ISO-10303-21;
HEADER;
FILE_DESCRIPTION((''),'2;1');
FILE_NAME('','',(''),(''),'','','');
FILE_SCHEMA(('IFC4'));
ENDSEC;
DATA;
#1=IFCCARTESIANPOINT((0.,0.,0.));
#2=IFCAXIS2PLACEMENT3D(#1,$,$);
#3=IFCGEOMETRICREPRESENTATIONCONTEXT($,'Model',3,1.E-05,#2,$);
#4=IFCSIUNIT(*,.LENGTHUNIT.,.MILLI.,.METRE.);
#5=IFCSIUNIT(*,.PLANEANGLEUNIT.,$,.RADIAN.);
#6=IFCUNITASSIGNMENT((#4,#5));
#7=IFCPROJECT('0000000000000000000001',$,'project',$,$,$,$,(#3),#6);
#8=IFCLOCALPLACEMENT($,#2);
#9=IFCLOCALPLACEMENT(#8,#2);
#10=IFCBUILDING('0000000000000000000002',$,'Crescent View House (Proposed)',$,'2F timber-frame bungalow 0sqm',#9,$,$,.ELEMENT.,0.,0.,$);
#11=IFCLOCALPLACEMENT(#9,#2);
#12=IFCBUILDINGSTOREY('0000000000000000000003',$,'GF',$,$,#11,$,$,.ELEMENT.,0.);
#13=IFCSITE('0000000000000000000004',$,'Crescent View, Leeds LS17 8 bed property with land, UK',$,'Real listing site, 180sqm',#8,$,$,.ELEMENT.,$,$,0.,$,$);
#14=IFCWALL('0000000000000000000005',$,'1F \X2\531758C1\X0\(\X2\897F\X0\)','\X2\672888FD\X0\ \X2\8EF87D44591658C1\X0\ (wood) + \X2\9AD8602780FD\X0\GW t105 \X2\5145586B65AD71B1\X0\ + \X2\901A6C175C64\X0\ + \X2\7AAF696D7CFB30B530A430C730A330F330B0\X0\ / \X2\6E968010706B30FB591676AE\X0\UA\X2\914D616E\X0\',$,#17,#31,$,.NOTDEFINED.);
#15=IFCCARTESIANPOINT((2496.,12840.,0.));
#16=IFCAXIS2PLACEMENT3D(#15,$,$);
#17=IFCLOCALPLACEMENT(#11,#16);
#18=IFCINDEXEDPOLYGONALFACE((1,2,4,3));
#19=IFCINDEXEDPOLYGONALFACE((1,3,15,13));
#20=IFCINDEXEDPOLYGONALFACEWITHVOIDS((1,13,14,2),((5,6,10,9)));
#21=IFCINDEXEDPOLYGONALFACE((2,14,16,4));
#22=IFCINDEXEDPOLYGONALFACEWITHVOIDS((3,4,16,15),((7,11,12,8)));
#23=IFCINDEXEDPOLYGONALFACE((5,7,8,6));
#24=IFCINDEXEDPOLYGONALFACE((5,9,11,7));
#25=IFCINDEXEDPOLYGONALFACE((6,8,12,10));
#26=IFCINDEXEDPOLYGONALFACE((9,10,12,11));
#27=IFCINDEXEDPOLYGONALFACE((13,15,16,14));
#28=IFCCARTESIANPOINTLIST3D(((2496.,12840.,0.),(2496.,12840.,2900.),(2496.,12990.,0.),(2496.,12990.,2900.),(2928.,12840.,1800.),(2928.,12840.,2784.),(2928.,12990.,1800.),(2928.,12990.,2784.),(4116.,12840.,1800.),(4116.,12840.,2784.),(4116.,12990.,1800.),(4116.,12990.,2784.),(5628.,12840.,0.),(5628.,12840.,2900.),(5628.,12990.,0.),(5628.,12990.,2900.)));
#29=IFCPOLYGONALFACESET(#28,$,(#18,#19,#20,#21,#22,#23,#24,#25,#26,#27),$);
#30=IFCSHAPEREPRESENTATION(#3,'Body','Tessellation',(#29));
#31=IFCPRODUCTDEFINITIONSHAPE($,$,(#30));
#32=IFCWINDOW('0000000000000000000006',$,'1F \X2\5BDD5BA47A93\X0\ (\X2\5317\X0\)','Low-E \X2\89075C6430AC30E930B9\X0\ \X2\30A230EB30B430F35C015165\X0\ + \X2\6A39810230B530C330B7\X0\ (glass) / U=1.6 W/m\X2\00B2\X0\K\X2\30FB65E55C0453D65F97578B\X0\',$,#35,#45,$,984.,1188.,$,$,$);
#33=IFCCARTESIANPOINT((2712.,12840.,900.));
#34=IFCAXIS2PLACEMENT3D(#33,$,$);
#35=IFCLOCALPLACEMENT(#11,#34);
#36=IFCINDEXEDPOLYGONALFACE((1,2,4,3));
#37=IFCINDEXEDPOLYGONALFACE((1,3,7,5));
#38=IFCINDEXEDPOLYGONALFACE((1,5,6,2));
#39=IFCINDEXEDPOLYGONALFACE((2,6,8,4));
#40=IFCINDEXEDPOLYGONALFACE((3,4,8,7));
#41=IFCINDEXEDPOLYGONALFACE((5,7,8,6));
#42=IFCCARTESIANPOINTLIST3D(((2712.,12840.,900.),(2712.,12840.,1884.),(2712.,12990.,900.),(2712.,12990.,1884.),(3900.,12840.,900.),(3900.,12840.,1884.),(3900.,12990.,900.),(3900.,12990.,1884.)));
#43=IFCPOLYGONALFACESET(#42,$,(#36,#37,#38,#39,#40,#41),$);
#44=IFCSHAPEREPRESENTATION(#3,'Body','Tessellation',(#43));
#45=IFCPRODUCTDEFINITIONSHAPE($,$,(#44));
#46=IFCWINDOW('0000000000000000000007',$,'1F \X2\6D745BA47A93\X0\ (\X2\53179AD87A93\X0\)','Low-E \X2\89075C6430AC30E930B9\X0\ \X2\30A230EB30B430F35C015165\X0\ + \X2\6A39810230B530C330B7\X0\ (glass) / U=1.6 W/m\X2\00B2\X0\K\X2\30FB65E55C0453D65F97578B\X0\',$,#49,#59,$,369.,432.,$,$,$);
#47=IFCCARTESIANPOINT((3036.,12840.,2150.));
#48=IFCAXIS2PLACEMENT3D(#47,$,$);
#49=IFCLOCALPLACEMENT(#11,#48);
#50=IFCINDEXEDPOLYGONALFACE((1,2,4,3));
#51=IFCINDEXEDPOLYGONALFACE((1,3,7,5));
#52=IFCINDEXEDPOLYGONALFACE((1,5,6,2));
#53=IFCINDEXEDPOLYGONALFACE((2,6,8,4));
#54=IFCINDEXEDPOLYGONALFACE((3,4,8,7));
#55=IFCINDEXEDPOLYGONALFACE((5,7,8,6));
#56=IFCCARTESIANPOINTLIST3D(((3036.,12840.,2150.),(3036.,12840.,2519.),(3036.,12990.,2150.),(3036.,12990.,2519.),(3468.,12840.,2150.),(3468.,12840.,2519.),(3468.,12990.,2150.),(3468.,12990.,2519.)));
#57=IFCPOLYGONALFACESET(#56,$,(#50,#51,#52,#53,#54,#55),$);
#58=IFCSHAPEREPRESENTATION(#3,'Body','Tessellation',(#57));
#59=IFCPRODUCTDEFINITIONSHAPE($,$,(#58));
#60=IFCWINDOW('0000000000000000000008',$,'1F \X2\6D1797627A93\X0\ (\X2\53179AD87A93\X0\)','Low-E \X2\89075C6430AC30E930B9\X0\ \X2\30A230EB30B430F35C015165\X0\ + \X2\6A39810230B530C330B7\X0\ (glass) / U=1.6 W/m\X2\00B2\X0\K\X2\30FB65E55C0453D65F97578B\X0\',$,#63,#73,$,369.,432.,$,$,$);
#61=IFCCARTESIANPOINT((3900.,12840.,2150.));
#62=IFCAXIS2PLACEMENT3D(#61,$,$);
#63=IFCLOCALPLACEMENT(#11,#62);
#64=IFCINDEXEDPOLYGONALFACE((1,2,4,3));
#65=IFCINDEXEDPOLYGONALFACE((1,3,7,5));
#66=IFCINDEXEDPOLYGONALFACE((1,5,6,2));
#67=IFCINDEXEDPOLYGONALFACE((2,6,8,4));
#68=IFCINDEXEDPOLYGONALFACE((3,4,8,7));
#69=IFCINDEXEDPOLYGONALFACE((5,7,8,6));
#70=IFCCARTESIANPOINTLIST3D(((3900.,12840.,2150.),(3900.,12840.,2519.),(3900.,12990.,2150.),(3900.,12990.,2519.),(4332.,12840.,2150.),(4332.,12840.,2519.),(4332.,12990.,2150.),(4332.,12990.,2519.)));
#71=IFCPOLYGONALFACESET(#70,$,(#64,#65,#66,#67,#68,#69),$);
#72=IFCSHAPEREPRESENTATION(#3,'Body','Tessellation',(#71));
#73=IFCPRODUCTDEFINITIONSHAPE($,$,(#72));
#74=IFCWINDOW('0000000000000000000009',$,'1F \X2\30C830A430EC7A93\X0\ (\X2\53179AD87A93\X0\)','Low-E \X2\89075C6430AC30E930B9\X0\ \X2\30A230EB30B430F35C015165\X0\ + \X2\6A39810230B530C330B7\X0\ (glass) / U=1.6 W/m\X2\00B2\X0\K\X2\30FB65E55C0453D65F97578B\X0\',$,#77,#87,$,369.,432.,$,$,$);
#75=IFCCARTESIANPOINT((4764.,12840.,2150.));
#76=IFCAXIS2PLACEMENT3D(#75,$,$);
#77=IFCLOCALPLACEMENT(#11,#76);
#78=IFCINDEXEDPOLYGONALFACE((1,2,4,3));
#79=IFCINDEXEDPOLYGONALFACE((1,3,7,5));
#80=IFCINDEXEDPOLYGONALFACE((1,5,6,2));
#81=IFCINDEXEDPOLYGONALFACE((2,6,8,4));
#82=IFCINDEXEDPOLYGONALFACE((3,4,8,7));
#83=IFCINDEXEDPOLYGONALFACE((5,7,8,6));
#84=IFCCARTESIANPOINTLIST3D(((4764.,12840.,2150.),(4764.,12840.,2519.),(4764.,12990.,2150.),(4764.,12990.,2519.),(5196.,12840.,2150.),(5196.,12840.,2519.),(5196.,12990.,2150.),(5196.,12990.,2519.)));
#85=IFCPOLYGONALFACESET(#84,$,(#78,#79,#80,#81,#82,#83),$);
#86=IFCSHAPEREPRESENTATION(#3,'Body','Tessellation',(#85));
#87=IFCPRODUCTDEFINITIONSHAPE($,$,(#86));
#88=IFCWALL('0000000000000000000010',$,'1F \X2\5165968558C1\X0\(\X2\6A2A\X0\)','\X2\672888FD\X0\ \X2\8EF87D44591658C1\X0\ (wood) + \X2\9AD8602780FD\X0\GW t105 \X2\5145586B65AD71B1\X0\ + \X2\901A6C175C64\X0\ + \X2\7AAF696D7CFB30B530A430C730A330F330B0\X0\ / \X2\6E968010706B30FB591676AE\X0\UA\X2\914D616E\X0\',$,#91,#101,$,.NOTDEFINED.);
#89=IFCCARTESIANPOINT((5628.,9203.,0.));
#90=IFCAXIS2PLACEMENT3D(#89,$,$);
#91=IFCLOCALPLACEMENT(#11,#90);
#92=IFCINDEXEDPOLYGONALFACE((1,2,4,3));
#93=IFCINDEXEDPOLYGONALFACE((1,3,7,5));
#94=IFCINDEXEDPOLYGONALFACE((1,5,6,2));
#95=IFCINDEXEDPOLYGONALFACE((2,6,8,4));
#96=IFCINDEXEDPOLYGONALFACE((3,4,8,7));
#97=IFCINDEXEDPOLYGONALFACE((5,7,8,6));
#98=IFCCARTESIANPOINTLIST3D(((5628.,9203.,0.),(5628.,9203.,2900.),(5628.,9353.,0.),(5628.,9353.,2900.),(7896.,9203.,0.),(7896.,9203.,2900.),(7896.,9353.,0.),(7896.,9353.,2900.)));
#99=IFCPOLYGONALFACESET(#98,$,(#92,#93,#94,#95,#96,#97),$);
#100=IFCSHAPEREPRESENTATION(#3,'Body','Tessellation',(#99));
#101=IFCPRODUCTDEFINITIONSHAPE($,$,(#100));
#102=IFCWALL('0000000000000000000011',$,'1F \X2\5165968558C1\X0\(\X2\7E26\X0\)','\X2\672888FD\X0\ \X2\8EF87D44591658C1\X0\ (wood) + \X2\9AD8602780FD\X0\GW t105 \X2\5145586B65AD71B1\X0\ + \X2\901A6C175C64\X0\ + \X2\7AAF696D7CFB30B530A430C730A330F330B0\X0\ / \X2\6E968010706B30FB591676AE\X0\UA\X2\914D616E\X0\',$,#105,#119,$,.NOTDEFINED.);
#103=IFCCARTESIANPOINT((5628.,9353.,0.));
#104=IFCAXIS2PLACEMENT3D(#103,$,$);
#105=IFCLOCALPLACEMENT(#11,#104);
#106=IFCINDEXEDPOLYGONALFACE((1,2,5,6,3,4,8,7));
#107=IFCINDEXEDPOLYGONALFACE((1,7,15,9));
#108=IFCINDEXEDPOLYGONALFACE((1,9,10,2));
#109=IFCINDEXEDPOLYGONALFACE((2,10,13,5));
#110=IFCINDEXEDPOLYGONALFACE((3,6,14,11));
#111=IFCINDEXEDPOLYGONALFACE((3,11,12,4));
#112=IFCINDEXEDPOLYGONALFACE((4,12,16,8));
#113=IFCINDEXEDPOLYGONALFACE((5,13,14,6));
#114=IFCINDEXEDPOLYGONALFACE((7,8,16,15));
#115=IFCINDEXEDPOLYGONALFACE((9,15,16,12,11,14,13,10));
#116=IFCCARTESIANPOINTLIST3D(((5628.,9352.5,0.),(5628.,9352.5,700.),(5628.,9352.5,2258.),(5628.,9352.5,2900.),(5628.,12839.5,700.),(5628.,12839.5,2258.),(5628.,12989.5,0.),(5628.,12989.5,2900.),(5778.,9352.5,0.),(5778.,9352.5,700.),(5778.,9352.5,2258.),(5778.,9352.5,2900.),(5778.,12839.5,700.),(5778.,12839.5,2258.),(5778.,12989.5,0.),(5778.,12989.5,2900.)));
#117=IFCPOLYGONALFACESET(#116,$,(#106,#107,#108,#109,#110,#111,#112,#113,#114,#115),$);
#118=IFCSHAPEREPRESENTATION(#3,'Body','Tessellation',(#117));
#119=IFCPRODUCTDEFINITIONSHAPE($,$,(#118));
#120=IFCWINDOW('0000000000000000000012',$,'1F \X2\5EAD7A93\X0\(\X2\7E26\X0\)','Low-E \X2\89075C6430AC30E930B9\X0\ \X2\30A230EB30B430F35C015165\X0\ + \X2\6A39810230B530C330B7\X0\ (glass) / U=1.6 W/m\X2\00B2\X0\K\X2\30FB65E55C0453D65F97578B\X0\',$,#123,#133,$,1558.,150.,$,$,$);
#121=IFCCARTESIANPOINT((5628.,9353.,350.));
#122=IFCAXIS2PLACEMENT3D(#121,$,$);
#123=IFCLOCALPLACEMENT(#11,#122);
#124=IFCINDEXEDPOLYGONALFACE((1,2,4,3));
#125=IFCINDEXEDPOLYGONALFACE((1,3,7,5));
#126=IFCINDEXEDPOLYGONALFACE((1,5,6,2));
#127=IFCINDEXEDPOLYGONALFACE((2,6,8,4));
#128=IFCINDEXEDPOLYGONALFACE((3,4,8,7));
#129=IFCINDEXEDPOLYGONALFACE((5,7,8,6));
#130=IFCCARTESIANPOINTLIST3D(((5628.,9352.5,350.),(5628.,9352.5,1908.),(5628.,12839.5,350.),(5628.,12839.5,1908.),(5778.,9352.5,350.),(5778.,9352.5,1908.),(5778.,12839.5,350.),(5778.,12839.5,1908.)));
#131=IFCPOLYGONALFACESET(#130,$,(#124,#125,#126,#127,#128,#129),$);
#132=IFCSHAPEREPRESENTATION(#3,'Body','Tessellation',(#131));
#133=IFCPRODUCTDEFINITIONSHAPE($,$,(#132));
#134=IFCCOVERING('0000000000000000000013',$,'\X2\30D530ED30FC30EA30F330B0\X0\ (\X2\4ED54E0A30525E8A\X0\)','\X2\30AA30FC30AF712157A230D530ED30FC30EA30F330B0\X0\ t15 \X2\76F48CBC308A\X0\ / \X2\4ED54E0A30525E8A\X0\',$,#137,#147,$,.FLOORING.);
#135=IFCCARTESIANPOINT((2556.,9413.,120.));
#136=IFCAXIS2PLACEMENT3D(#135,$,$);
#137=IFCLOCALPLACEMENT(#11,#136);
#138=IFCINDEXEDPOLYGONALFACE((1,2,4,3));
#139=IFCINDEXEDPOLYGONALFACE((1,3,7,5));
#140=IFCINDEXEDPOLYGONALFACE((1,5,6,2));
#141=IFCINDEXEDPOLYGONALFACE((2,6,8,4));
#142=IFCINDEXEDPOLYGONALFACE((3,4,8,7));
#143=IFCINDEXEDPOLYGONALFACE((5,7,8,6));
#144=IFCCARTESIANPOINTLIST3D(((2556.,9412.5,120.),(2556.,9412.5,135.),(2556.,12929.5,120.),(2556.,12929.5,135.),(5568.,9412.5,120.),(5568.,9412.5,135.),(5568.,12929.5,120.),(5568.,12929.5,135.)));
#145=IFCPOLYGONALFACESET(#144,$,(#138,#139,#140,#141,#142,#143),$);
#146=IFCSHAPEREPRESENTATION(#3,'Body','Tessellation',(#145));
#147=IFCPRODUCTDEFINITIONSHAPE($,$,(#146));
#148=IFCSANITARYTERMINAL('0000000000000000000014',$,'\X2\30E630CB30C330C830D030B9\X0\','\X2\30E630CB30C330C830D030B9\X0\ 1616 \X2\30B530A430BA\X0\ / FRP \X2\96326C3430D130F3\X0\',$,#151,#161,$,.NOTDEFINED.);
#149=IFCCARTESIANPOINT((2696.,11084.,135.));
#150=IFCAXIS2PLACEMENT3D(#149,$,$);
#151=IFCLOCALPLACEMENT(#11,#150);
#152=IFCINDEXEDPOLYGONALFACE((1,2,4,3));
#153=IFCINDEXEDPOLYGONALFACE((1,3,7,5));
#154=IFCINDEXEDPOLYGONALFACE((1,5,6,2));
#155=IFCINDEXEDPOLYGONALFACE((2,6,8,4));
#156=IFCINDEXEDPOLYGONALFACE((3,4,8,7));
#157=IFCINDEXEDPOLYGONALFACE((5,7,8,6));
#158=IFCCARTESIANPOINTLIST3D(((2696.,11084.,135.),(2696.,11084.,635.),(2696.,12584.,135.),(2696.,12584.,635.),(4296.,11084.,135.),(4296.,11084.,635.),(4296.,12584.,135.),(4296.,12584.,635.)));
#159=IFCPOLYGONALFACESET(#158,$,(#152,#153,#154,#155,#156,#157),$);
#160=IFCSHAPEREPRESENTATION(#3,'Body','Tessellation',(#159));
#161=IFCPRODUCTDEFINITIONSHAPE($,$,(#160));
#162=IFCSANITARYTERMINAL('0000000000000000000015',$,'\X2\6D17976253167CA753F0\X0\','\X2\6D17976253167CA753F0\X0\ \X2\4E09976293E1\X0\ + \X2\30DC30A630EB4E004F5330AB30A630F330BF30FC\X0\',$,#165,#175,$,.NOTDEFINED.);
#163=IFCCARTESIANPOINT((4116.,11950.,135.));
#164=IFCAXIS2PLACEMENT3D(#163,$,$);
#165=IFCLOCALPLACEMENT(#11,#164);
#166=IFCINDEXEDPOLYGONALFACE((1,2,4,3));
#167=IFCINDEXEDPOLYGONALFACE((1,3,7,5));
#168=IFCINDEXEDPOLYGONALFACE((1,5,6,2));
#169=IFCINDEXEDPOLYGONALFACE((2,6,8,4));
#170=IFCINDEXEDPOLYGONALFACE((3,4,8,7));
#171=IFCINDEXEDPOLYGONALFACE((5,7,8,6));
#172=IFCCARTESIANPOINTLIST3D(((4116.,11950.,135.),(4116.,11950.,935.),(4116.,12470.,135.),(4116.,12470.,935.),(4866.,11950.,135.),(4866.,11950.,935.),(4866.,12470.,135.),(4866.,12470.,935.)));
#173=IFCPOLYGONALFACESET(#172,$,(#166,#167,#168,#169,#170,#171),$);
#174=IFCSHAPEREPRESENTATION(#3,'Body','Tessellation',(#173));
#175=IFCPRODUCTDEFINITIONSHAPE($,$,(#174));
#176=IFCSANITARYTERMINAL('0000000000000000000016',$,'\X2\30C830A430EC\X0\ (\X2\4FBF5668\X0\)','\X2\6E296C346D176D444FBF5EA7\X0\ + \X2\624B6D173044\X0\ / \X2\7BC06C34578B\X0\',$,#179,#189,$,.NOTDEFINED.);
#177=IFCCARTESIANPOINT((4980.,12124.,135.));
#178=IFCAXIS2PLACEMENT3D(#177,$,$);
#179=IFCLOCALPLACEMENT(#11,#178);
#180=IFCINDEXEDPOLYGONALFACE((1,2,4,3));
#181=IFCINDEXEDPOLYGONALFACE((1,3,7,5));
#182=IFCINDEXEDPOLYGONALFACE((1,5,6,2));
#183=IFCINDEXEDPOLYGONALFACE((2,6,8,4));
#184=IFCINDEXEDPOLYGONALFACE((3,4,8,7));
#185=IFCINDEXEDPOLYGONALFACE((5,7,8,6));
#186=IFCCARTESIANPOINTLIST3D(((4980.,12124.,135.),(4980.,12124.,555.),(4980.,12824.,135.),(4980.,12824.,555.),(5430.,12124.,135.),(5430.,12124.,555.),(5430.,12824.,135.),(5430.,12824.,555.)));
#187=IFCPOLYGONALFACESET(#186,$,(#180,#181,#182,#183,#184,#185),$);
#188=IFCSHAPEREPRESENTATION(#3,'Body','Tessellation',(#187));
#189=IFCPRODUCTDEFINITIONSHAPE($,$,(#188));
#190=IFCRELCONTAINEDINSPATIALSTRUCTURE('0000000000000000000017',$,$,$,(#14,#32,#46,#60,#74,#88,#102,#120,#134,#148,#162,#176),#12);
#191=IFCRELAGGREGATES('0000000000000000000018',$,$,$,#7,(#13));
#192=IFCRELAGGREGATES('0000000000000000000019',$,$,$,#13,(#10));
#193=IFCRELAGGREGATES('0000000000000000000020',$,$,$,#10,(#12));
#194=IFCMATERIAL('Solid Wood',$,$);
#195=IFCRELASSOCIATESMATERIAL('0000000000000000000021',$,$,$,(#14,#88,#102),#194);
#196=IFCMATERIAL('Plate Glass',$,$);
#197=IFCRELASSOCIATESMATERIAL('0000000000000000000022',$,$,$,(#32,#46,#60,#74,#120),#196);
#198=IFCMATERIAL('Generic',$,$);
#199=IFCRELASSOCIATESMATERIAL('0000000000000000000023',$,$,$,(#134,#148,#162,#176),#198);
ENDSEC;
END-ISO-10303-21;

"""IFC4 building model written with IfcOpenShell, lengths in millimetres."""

from ifc_helpers import new_model, si_unit, frame, frame_2d, origin, place, context, project, spatial, rectangle, extrude, material, element, fill, save


model = new_model("IFC4")

# Units and contexts
model_context = context("Model", 3, precision=1e-05, world=origin())
ifc_project = project(units=[si_unit("LENGTHUNIT", "METRE", prefix="MILLI"), si_unit("PLANEANGLEUNIT", "RADIAN")], contexts=[model_context])

# Site, building, storey
site_placement = place(None, origin())
site = spatial("IfcSite", under=ifc_project, at=site_placement, Name="Crescent View, Leeds LS17 8 bed property with land, UK", ObjectType="Real listing site, 180sqm", CompositionType="ELEMENT", RefElevation=0.0)
building_placement = place(site_placement, origin())
building = spatial("IfcBuilding", under=site, at=building_placement, Name="Crescent View House (Proposed)", ObjectType="2F timber-frame bungalow 0sqm", CompositionType="ELEMENT", ElevationOfRefHeight=0.0, ElevationOfTerrain=0.0)
storey_placement = place(building_placement, origin())
storey = spatial("IfcBuildingStorey", under=building, at=storey_placement, Name="GF", CompositionType="ELEMENT", Elevation=0.0)

# Shared definitions
ifc_material_1 = material(Name="Solid Wood")

# Wall, openings, windows
wall_1_placement = place(storey_placement, frame((2496.0, 12840.0, 0.0)))
wall_1 = element("IfcWall", 1, at=wall_1_placement, inside=storey, material=ifc_material_1, Name="1F 北壁(西)", Description="木製 軸組外壁 (wood) + 高性能GW t105 充填断熱 + 通気層 + 窯業系サイディング / 準耐火・外皮UA配慮", PredefinedType="NOTDEFINED", context=model_context, shape_type="SweptSolid", body=[
    extrude(rectangle(XDim=3132.0, YDim=150.0, at=frame_2d((1566.0, 75.0))), frame((2496.0, 12840.0, 0.0)), (0.0, 0.0, 1.0), 2900.0),
])
opening_1_placement = place(storey_placement, frame((2712.0, 12840.0, 900.0)))
opening_1 = element("IfcOpeningElement", 2, at=opening_1_placement, cuts=wall_1, PredefinedType="NOTDEFINED", context=model_context, shape_type="SweptSolid", body=[
    extrude(rectangle(XDim=1188.0, YDim=150.0, at=frame_2d((594.0, 75.0))), frame((2712.0, 12840.0, 900.0)), (0.0, 0.0, 1.0), 984.0),
])
opening_2_placement = place(storey_placement, frame((3036.0, 12840.0, 2150.0)))
opening_2 = element("IfcOpeningElement", 3, at=opening_2_placement, cuts=wall_1, PredefinedType="NOTDEFINED", context=model_context, shape_type="SweptSolid", body=[
    extrude(rectangle(XDim=432.0, YDim=150.0, at=frame_2d((216.0, 75.0))), frame((3036.0, 12840.0, 2150.0)), (0.0, 0.0, 1.0), 369.0),
])
opening_3_placement = place(storey_placement, frame((3900.0, 12840.0, 2150.0)))
opening_3 = element("IfcOpeningElement", 4, at=opening_3_placement, cuts=wall_1, PredefinedType="NOTDEFINED", context=model_context, shape_type="SweptSolid", body=[
    extrude(rectangle(XDim=432.0, YDim=150.0, at=frame_2d((216.0, 75.0))), frame((3900.0, 12840.0, 2150.0)), (0.0, 0.0, 1.0), 369.0),
])
opening_4_placement = place(storey_placement, frame((4764.0, 12840.0, 2150.0)))
opening_4 = element("IfcOpeningElement", 5, at=opening_4_placement, cuts=wall_1, PredefinedType="NOTDEFINED", context=model_context, shape_type="SweptSolid", body=[
    extrude(rectangle(XDim=432.0, YDim=150.0, at=frame_2d((216.0, 75.0))), frame((4764.0, 12840.0, 2150.0)), (0.0, 0.0, 1.0), 369.0),
])
ifc_material_2 = material(Name="Plate Glass")
window_1_placement = place(storey_placement, frame((2712.0, 12840.0, 900.0)))
window_1 = element("IfcWindow", 6, at=window_1_placement, inside=storey, material=ifc_material_2, Name="1F 寝室窓 (北)", Description="Low-E 複層ガラス アルゴン封入 + 樹脂サッシ (glass) / U=1.6 W/m²K・日射取得型", OverallHeight=984.0, OverallWidth=1188.0, context=model_context, shape_type="SweptSolid", body=[
    extrude(rectangle(XDim=1188.0, YDim=150.0, at=frame_2d((594.0, 75.0))), frame((2712.0, 12840.0, 900.0)), (0.0, 0.0, 1.0), 984.0),
])
fill(opening_1, window_1)
window_2_placement = place(storey_placement, frame((3036.0, 12840.0, 2150.0)))
window_2 = element("IfcWindow", 7, at=window_2_placement, inside=storey, material=ifc_material_2, Name="1F 浴室窓 (北高窓)", Description="Low-E 複層ガラス アルゴン封入 + 樹脂サッシ (glass) / U=1.6 W/m²K・日射取得型", OverallHeight=369.0, OverallWidth=432.0, context=model_context, shape_type="SweptSolid", body=[
    extrude(rectangle(XDim=432.0, YDim=150.0, at=frame_2d((216.0, 75.0))), frame((3036.0, 12840.0, 2150.0)), (0.0, 0.0, 1.0), 369.0),
])
fill(opening_2, window_2)
window_3_placement = place(storey_placement, frame((3900.0, 12840.0, 2150.0)))
window_3 = element("IfcWindow", 8, at=window_3_placement, inside=storey, material=ifc_material_2, Name="1F 洗面窓 (北高窓)", Description="Low-E 複層ガラス アルゴン封入 + 樹脂サッシ (glass) / U=1.6 W/m²K・日射取得型", OverallHeight=369.0, OverallWidth=432.0, context=model_context, shape_type="SweptSolid", body=[
    extrude(rectangle(XDim=432.0, YDim=150.0, at=frame_2d((216.0, 75.0))), frame((3900.0, 12840.0, 2150.0)), (0.0, 0.0, 1.0), 369.0),
])
fill(opening_3, window_3)
window_4_placement = place(storey_placement, frame((4764.0, 12840.0, 2150.0)))
window_4 = element("IfcWindow", 9, at=window_4_placement, inside=storey, material=ifc_material_2, Name="1F トイレ窓 (北高窓)", Description="Low-E 複層ガラス アルゴン封入 + 樹脂サッシ (glass) / U=1.6 W/m²K・日射取得型", OverallHeight=369.0, OverallWidth=432.0, context=model_context, shape_type="SweptSolid", body=[
    extrude(rectangle(XDim=432.0, YDim=150.0, at=frame_2d((216.0, 75.0))), frame((4764.0, 12840.0, 2150.0)), (0.0, 0.0, 1.0), 369.0),
])
fill(opening_4, window_4)

# Wall
wall_2_placement = place(storey_placement, frame((5628.0, 9203.0, 0.0)))
element("IfcWall", 10, at=wall_2_placement, inside=storey, material=ifc_material_1, Name="1F 入隅壁(横)", Description="木製 軸組外壁 (wood) + 高性能GW t105 充填断熱 + 通気層 + 窯業系サイディング / 準耐火・外皮UA配慮", PredefinedType="NOTDEFINED", context=model_context, shape_type="SweptSolid", body=[
    extrude(rectangle(XDim=2268.0, YDim=150.0, at=frame_2d((1134.0, 75.0))), frame((5628.0, 9203.0, 0.0)), (0.0, 0.0, 1.0), 2900.0),
])

# Wall, opening, window
wall_3_placement = place(storey_placement, frame((5628.0, 9353.0, 0.0)))
wall_3 = element("IfcWall", 11, at=wall_3_placement, inside=storey, material=ifc_material_1, Name="1F 入隅壁(縦)", Description="木製 軸組外壁 (wood) + 高性能GW t105 充填断熱 + 通気層 + 窯業系サイディング / 準耐火・外皮UA配慮", PredefinedType="NOTDEFINED", context=model_context, shape_type="SweptSolid", body=[
    extrude(rectangle(XDim=150.0, YDim=3637.0, at=frame_2d((75.0, 1818.0))), frame((5628.0, 9353.0, 0.0)), (0.0, 0.0, 1.0), 2900.0),
])
opening_5_placement = place(storey_placement, frame((5628.0, 9353.0, 350.0)))
opening_5 = element("IfcOpeningElement", 12, at=opening_5_placement, cuts=wall_3, PredefinedType="NOTDEFINED", context=model_context, shape_type="SweptSolid", body=[
    extrude(rectangle(XDim=150.0, YDim=3487.0, at=frame_2d((75.0, 1743.0))), frame((5628.0, 9353.0, 350.0)), (0.0, 0.0, 1.0), 1558.0),
])
window_5_placement = place(storey_placement, frame((5628.0, 9353.0, 350.0)))
window_5 = element("IfcWindow", 13, at=window_5_placement, inside=storey, material=ifc_material_2, Name="1F 庭窓(縦)", Description="Low-E 複層ガラス アルゴン封入 + 樹脂サッシ (glass) / U=1.6 W/m²K・日射取得型", OverallHeight=1558.0, OverallWidth=150.0, context=model_context, shape_type="SweptSolid", body=[
    extrude(rectangle(XDim=150.0, YDim=3487.0, at=frame_2d((75.0, 1743.0))), frame((5628.0, 9353.0, 350.0)), (0.0, 0.0, 1.0), 1558.0),
])
fill(opening_5, window_5)

# Covering
ifc_material_3 = material(Name="Generic")
covering_placement = place(storey_placement, frame((2556.0, 9413.0, 120.0)))
element("IfcCovering", 14, at=covering_placement, inside=storey, material=ifc_material_3, Name="フローリング (仕上げ床)", Description="オーク無垢フローリング t15 直貼り / 仕上げ床", PredefinedType="FLOORING", context=model_context, shape_type="SweptSolid", body=[
    extrude(rectangle(XDim=3012.0, YDim=3517.0, at=frame_2d((1506.0, 1758.0))), frame((2556.0, 9413.0, 120.0)), (0.0, 0.0, 1.0), 15.0),
])

# Sanitary terminals
sanitary_terminal_1_placement = place(storey_placement, frame((2696.0, 11084.0, 135.0)))
element("IfcSanitaryTerminal", 15, at=sanitary_terminal_1_placement, inside=storey, material=ifc_material_3, Name="ユニットバス", Description="ユニットバス 1616 サイズ / FRP 防水パン", PredefinedType="NOTDEFINED", context=model_context, shape_type="SweptSolid", body=[
    extrude(rectangle(XDim=1600.0, YDim=1500.0, at=frame_2d((800.0, 750.0))), frame((2696.0, 11084.0, 135.0)), (0.0, 0.0, 1.0), 500.0),
])
sanitary_terminal_2_placement = place(storey_placement, frame((4116.0, 11950.0, 135.0)))
element("IfcSanitaryTerminal", 16, at=sanitary_terminal_2_placement, inside=storey, material=ifc_material_3, Name="洗面化粧台", Description="洗面化粧台 三面鏡 + ボウル一体カウンター", PredefinedType="NOTDEFINED", context=model_context, shape_type="SweptSolid", body=[
    extrude(rectangle(XDim=750.0, YDim=520.0, at=frame_2d((375.0, 260.0))), frame((4116.0, 11950.0, 135.0)), (0.0, 0.0, 1.0), 800.0),
])
sanitary_terminal_3_placement = place(storey_placement, frame((4980.0, 12124.0, 135.0)))
element("IfcSanitaryTerminal", 17, at=sanitary_terminal_3_placement, inside=storey, material=ifc_material_3, Name="トイレ (便器)", Description="温水洗浄便座 + 手洗い / 節水型", PredefinedType="NOTDEFINED", context=model_context, shape_type="SweptSolid", body=[
    extrude(rectangle(XDim=450.0, YDim=700.0, at=frame_2d((225.0, 350.0))), frame((4980.0, 12124.0, 135.0)), (0.0, 0.0, 1.0), 420.0),
])

save(model, "model.ifc")
